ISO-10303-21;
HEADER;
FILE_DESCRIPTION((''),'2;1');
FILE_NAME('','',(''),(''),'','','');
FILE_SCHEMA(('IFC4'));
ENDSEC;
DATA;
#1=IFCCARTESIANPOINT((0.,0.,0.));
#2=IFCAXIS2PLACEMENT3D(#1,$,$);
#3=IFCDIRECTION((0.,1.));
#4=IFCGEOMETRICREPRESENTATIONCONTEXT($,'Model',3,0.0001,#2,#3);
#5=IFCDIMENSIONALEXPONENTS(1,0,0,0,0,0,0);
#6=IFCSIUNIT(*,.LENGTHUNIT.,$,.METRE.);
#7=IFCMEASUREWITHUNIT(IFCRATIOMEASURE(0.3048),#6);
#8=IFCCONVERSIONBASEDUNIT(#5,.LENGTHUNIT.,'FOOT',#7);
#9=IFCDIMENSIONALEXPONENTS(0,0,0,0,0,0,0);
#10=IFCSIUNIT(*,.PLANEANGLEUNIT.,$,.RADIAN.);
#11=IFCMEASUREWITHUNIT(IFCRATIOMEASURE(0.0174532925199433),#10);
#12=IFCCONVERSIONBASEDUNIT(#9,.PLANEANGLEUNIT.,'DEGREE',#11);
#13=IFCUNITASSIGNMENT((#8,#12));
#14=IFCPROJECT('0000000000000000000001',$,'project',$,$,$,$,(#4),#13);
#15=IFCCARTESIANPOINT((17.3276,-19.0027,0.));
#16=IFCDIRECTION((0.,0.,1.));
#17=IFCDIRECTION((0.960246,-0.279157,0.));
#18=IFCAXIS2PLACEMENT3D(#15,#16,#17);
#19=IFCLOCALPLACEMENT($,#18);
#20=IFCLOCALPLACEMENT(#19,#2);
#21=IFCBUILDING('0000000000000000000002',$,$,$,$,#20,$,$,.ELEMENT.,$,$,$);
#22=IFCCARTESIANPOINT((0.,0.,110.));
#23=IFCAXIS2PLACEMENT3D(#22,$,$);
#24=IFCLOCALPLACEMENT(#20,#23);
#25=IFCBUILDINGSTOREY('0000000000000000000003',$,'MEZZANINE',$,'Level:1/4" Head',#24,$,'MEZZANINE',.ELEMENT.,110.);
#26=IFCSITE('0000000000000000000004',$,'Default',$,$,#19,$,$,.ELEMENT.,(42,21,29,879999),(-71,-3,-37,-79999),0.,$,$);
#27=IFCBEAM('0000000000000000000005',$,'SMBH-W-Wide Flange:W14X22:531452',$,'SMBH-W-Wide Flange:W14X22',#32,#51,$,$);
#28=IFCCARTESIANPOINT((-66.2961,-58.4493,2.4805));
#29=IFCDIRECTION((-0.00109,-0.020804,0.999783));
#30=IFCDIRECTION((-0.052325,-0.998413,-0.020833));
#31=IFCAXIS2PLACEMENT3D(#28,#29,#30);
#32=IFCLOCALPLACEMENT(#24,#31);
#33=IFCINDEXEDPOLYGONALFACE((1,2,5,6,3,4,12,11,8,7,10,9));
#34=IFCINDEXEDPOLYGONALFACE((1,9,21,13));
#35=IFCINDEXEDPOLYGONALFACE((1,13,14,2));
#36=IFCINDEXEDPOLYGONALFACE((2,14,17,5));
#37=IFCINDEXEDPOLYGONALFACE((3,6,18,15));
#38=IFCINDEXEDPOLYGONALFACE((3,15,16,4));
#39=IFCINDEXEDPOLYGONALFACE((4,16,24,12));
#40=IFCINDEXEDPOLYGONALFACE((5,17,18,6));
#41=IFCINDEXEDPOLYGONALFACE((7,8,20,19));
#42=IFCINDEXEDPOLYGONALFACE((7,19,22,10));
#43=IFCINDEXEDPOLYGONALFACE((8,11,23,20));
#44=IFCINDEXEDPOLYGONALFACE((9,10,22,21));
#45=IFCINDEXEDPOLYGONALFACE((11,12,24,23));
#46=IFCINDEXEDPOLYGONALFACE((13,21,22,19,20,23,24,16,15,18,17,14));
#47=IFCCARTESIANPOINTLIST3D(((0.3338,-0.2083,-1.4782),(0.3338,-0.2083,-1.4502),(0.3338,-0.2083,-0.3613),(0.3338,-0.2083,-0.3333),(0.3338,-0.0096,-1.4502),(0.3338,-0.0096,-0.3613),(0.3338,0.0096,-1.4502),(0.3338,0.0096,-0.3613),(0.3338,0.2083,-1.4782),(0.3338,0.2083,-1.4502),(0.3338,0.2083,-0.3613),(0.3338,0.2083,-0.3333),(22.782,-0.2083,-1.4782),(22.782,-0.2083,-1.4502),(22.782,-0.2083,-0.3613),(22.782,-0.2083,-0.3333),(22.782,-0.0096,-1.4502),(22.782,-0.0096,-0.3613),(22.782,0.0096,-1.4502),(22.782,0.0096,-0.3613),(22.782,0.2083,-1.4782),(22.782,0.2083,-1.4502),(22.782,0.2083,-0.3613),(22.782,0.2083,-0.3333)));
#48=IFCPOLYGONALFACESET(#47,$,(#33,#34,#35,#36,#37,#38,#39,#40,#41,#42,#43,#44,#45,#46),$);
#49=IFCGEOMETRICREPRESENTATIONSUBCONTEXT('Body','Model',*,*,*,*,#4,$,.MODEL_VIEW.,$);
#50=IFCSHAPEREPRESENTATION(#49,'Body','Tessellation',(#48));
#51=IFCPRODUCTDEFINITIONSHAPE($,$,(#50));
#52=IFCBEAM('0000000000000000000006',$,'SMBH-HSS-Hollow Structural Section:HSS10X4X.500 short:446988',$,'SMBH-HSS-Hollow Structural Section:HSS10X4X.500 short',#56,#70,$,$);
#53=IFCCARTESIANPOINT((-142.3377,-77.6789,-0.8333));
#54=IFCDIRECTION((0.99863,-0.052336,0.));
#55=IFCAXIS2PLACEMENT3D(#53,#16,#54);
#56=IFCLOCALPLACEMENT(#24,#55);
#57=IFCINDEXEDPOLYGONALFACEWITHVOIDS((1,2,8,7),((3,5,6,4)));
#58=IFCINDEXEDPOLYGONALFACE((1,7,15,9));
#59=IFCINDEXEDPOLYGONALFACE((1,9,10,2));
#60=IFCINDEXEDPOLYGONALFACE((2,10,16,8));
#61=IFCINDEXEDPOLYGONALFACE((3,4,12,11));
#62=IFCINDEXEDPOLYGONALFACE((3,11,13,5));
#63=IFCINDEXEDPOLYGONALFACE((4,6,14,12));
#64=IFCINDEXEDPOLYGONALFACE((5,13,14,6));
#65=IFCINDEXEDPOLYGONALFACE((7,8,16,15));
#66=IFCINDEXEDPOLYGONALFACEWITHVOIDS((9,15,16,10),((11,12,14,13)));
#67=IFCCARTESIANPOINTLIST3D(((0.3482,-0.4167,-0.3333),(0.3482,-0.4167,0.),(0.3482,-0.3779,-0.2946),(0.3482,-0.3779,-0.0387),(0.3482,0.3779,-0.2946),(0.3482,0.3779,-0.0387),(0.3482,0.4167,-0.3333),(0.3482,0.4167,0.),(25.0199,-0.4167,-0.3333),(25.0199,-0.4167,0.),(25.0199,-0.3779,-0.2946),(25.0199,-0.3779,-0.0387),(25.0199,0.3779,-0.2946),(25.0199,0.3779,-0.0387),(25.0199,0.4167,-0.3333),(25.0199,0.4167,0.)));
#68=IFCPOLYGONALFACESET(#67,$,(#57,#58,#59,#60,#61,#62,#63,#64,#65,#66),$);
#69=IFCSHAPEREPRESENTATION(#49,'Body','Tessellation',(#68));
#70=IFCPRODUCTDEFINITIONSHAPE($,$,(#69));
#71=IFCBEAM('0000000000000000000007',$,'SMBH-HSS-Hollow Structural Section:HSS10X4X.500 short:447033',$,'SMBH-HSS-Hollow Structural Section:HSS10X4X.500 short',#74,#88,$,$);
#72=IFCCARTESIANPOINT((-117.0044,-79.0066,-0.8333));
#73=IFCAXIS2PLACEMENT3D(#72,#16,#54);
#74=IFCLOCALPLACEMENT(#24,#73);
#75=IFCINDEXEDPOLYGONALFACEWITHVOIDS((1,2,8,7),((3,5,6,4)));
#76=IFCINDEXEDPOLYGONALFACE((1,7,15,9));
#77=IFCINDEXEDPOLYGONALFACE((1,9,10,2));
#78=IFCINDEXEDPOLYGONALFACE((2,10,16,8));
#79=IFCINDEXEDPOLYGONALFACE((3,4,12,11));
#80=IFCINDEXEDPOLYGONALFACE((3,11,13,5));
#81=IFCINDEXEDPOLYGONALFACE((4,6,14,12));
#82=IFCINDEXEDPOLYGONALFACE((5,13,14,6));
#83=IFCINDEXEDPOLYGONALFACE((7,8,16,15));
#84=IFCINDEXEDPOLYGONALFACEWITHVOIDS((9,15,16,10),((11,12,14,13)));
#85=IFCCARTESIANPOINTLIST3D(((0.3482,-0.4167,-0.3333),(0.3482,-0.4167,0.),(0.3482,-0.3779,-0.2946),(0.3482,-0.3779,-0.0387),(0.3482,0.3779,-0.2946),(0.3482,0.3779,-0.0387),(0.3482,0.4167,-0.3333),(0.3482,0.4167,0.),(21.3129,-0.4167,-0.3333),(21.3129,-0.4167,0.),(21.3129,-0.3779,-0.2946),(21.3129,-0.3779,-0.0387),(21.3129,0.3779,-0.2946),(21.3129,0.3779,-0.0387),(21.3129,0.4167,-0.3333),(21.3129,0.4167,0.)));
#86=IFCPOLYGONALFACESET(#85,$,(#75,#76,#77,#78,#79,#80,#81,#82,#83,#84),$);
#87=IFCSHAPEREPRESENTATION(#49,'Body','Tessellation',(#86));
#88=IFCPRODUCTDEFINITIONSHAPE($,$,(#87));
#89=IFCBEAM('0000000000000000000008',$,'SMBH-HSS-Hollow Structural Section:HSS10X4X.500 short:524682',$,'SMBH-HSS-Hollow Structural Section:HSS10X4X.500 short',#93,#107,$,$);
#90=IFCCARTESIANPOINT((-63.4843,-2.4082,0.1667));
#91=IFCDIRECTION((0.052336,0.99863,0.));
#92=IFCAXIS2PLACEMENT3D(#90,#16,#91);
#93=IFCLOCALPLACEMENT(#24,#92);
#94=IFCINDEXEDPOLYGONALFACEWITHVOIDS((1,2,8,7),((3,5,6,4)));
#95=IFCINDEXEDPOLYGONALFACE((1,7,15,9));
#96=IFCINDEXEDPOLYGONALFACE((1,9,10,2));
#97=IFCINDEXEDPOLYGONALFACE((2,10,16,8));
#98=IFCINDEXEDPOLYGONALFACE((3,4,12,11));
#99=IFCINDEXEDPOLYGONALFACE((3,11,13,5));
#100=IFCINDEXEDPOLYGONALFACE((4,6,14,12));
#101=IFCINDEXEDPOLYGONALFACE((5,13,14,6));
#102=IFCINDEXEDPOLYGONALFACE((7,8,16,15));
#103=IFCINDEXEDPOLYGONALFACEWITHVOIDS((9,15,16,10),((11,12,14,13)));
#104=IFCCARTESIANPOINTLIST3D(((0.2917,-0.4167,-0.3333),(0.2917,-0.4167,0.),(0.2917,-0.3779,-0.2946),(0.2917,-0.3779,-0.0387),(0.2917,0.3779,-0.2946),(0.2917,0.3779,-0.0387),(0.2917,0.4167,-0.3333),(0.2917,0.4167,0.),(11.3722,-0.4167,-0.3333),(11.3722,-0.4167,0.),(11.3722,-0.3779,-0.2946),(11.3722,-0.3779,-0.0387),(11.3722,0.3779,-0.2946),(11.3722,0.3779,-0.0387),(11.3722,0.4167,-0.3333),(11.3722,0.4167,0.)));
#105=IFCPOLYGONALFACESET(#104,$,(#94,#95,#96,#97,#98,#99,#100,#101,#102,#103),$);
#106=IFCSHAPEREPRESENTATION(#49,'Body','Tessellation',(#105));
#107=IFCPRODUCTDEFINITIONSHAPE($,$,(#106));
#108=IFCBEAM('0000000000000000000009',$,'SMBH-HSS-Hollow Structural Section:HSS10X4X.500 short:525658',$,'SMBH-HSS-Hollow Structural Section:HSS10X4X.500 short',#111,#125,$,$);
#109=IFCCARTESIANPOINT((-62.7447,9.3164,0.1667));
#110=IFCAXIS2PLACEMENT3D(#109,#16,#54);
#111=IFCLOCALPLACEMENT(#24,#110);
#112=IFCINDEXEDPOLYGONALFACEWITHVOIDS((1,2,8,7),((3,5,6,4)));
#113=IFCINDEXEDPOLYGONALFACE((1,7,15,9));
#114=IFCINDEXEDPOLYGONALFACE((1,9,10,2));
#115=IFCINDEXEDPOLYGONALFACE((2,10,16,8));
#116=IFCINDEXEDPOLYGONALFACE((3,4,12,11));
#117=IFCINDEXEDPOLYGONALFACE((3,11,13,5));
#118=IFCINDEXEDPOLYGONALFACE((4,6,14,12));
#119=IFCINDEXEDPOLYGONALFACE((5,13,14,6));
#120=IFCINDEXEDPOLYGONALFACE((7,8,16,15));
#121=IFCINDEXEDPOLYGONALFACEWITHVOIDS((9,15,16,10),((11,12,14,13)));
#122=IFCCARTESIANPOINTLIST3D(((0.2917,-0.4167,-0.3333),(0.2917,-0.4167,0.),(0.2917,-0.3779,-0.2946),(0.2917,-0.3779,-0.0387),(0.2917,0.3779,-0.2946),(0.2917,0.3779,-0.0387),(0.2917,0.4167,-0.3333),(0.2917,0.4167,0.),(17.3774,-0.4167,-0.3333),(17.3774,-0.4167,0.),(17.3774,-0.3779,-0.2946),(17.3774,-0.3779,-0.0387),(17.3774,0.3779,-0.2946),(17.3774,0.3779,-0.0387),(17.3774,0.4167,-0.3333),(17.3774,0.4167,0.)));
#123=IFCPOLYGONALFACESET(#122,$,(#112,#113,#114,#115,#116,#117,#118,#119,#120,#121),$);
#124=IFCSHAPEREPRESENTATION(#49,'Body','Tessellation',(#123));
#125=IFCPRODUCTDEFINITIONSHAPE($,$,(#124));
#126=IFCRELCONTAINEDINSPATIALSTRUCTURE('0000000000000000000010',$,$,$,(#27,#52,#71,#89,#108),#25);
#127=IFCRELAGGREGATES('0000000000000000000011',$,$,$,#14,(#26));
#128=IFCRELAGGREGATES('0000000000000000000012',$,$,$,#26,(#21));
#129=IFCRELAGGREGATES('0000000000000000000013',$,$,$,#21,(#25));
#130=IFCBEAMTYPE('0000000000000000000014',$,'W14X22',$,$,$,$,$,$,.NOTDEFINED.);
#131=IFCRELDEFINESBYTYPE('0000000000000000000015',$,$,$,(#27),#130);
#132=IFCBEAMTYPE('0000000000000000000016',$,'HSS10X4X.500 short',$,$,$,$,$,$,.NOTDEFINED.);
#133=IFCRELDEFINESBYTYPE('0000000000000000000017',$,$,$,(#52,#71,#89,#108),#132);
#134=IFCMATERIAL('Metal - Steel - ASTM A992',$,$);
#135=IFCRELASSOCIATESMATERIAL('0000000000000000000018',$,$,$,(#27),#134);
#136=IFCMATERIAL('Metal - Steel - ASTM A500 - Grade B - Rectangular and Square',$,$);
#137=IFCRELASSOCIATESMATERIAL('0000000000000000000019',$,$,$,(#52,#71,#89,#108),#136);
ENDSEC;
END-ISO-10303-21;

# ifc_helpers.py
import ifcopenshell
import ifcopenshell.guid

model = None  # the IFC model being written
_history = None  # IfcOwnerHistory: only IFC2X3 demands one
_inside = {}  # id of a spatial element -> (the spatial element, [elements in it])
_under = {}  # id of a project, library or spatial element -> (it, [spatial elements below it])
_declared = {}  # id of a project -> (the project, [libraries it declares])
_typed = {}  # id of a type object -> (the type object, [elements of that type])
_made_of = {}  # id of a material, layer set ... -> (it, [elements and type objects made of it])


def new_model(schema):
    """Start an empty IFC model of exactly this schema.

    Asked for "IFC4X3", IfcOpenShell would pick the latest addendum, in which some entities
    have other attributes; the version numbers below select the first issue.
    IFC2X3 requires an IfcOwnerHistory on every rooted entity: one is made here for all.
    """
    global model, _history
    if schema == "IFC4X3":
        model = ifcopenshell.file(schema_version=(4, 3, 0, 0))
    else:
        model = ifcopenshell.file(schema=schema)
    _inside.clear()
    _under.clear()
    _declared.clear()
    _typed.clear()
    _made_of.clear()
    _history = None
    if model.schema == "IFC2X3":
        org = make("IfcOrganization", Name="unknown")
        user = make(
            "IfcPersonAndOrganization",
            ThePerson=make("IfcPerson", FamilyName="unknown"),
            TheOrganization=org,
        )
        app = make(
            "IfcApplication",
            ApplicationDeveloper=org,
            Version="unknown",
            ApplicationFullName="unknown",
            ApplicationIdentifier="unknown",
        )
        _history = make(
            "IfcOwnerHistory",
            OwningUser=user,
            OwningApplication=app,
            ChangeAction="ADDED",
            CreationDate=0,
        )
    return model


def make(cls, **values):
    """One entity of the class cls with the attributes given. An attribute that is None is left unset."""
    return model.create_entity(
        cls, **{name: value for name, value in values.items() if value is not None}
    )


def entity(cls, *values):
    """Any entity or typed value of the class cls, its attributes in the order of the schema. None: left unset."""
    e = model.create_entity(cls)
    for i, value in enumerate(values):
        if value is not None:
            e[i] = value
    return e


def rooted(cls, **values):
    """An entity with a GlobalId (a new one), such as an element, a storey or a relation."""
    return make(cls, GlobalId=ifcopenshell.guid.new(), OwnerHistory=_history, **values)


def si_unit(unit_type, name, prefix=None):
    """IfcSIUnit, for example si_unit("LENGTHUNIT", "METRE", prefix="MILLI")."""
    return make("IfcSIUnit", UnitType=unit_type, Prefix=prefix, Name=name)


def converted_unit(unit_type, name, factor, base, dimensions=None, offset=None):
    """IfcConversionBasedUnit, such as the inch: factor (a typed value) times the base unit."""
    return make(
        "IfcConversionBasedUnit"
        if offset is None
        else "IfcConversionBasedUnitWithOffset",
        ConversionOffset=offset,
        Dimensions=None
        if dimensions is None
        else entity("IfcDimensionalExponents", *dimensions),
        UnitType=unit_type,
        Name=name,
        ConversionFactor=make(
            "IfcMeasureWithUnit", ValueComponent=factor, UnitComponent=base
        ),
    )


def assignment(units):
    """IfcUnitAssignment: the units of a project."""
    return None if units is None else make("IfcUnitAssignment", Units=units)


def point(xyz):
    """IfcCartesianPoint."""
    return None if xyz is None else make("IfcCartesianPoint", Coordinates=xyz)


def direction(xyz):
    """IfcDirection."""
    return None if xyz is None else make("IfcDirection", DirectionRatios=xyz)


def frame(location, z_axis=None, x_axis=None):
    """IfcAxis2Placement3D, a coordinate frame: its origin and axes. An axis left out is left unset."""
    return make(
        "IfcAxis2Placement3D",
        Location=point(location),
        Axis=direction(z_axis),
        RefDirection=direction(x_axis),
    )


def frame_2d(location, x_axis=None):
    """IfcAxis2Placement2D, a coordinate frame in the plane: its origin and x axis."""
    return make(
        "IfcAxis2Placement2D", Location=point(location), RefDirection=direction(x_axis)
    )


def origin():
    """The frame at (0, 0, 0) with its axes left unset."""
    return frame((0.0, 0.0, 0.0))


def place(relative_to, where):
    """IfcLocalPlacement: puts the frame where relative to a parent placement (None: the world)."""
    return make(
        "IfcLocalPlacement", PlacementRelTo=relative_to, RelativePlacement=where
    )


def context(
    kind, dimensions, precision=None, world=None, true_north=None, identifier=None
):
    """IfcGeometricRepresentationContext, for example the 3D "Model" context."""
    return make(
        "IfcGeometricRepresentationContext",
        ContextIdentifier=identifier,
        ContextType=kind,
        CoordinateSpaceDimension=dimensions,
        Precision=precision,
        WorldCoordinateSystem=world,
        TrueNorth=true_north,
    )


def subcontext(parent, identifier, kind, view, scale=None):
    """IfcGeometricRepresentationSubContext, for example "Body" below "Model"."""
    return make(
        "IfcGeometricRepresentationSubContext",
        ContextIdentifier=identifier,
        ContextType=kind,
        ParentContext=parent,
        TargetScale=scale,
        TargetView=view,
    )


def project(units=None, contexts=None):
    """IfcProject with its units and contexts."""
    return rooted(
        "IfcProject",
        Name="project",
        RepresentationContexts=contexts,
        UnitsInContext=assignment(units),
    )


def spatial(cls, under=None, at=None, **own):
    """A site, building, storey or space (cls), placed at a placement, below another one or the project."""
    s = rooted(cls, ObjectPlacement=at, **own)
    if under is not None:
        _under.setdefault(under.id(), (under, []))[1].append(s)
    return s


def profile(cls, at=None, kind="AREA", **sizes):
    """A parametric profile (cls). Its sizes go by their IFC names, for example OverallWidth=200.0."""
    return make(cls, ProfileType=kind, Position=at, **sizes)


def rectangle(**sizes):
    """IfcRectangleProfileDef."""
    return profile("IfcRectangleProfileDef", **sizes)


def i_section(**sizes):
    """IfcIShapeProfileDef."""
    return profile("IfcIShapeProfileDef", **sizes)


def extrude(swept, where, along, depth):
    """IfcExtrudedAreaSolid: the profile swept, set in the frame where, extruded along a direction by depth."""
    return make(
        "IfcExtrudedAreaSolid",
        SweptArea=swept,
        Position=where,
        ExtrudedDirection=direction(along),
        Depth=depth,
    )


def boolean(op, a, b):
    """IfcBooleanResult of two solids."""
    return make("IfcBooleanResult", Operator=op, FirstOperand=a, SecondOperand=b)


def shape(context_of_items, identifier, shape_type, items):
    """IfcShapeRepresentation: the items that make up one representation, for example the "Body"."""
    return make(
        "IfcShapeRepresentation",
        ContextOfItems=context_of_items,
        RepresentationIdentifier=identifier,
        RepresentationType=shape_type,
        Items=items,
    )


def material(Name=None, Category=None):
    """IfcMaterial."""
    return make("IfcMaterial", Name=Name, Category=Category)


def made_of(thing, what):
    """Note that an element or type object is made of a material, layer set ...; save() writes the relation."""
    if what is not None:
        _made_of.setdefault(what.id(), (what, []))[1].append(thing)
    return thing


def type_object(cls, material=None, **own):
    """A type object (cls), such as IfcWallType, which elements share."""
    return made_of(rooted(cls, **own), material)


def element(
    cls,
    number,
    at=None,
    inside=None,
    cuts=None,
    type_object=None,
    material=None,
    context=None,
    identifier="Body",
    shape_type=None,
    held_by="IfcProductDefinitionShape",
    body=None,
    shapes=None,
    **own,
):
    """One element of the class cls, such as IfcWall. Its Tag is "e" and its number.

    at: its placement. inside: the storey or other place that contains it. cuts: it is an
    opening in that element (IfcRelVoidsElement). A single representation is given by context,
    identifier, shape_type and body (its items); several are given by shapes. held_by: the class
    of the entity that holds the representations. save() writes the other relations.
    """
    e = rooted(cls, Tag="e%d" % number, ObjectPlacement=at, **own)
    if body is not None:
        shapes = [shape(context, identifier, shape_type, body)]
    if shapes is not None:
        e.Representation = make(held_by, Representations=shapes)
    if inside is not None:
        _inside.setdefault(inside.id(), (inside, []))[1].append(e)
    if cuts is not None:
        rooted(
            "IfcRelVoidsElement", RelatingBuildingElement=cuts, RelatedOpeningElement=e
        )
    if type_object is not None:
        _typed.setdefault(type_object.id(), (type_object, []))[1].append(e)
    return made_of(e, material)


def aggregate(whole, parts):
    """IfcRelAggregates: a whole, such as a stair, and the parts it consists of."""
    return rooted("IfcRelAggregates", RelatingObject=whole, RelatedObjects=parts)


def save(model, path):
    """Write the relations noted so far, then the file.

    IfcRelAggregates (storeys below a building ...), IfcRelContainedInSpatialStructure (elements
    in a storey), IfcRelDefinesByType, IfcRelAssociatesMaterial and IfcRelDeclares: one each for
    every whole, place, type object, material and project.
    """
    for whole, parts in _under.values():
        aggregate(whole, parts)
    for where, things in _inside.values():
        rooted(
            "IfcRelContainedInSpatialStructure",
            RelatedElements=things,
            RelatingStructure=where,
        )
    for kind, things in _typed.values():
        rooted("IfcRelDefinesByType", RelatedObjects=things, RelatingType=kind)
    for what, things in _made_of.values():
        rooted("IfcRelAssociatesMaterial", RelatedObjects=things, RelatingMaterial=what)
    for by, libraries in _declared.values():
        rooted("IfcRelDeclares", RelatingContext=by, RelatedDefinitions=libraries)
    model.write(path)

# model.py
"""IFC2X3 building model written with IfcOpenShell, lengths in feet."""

from ifc_helpers import new_model, entity, si_unit, converted_unit, direction, frame, frame_2d, origin, place, context, subcontext, project, spatial, rectangle, i_section, extrude, boolean, material, type_object, element, save


model = new_model("IFC2X3")

# Units and contexts
model_context = context("Model", 3, precision=0.0001, world=origin(), true_north=direction((0.0, 1.0)))
body_context = subcontext(model_context, "Body", "Model", "MODEL_VIEW")
ifc_project = project(units=[converted_unit("LENGTHUNIT", "FOOT", entity("IfcRatioMeasure", 0.3048), si_unit("LENGTHUNIT", "METRE"), dimensions=[1, 0, 0, 0, 0, 0, 0]), converted_unit("PLANEANGLEUNIT", "DEGREE", entity("IfcRatioMeasure", 0.0174532925199433), si_unit("PLANEANGLEUNIT", "RADIAN"), dimensions=[0, 0, 0, 0, 0, 0, 0])], contexts=[model_context])

# Site, building, storey
site_placement = place(None, frame((17.3276, -19.0027, 0.0), z_axis=(0.0, 0.0, 1.0), x_axis=(0.960246, -0.279157, 0.0)))
site = spatial("IfcSite", under=ifc_project, at=site_placement, Name="Default", CompositionType="ELEMENT", RefLatitude=(42, 21, 29, 879999), RefLongitude=(-71, -3, -37, -79999), RefElevation=0.0)
building_placement = place(site_placement, origin())
building = spatial("IfcBuilding", under=site, at=building_placement, CompositionType="ELEMENT")
storey_placement = place(building_placement, frame((0.0, 0.0, 110.0)))
storey = spatial("IfcBuildingStorey", under=building, at=storey_placement, Name="MEZZANINE", ObjectType="Level:1/4\" Head", LongName="MEZZANINE", CompositionType="ELEMENT", Elevation=110.0)

# Beams
ifc_material_1 = material(Name="Metal - Steel - ASTM A992")
beam_type_1 = type_object("IfcBeamType", Name="W14X22", PredefinedType="NOTDEFINED")
beam_1_placement = place(storey_placement, frame((-66.2961, -58.4493, 2.4805), z_axis=(-0.00109, -0.020804, 0.999783), x_axis=(-0.052325, -0.998413, -0.020833)))
element("IfcBeam", 1, at=beam_1_placement, inside=storey, type_object=beam_type_1, material=ifc_material_1, Name="SMBH-W-Wide Flange:W14X22:531452", ObjectType="SMBH-W-Wide Flange:W14X22", context=body_context, shape_type="SweptSolid", body=[
    extrude(i_section(OverallWidth=0.4167, OverallDepth=1.1449, WebThickness=0.0192, FlangeThickness=0.028, at=frame_2d((0.0, 0.0), x_axis=(0.0, 1.0))), frame((0.3338, 0.0, -0.9058), z_axis=(1.0, 0.0, 0.0), x_axis=(0.0, 0.0, -1.0)), (0.0, 0.0, 1.0), 22.4482),
])
ifc_material_2 = material(Name="Metal - Steel - ASTM A500 - Grade B - Rectangular and Square")
beam_type_2 = type_object("IfcBeamType", Name="HSS10X4X.500 short", PredefinedType="NOTDEFINED")
beam_2_placement = place(storey_placement, frame((-142.3377, -77.6789, -0.8333), z_axis=(0.0, 0.0, 1.0), x_axis=(0.99863, -0.052336, 0.0)))
element("IfcBeam", 2, at=beam_2_placement, inside=storey, type_object=beam_type_2, material=ifc_material_2, Name="SMBH-HSS-Hollow Structural Section:HSS10X4X.500 short:446988", ObjectType="SMBH-HSS-Hollow Structural Section:HSS10X4X.500 short", context=body_context, shape_type="SweptSolid", body=[
    boolean("DIFFERENCE", extrude(rectangle(XDim=0.3333, YDim=0.8333, at=frame_2d((0.0, 0.0), x_axis=(1.0, 0.0))), frame((0.3482, 0.0, -0.1667), z_axis=(1.0, 0.0, 0.0), x_axis=(0.0, 0.0, -1.0)), (0.0, 0.0, 1.0), 24.6717), extrude(rectangle(XDim=0.2559, YDim=0.7559, at=frame_2d((0.0, 0.0), x_axis=(0.0, 1.0))), frame((25.0199, 0.0, -0.1667), z_axis=(-1.0, 0.0, 0.0), x_axis=(0.0, 1.0, 0.0)), (0.0, 0.0, 1.0), 24.6717)),
])
beam_3_placement = place(storey_placement, frame((-117.0044, -79.0066, -0.8333), z_axis=(0.0, 0.0, 1.0), x_axis=(0.99863, -0.052336, 0.0)))
element("IfcBeam", 3, at=beam_3_placement, inside=storey, type_object=beam_type_2, material=ifc_material_2, Name="SMBH-HSS-Hollow Structural Section:HSS10X4X.500 short:447033", ObjectType="SMBH-HSS-Hollow Structural Section:HSS10X4X.500 short", context=body_context, shape_type="SweptSolid", body=[
    boolean("DIFFERENCE", extrude(rectangle(XDim=0.3333, YDim=0.8333, at=frame_2d((0.0, 0.0), x_axis=(1.0, 0.0))), frame((0.3482, 0.0, -0.1667), z_axis=(1.0, 0.0, 0.0), x_axis=(0.0, 0.0, -1.0)), (0.0, 0.0, 1.0), 20.9647), extrude(rectangle(XDim=0.2559, YDim=0.7559, at=frame_2d((0.0, 0.0), x_axis=(0.0, 1.0))), frame((21.3129, 0.0, -0.1667), z_axis=(-1.0, 0.0, 0.0), x_axis=(0.0, 1.0, 0.0)), (0.0, 0.0, 1.0), 20.9647)),
])
beam_4_placement = place(storey_placement, frame((-63.4843, -2.4082, 0.1667), z_axis=(0.0, 0.0, 1.0), x_axis=(0.052336, 0.99863, 0.0)))
element("IfcBeam", 4, at=beam_4_placement, inside=storey, type_object=beam_type_2, material=ifc_material_2, Name="SMBH-HSS-Hollow Structural Section:HSS10X4X.500 short:524682", ObjectType="SMBH-HSS-Hollow Structural Section:HSS10X4X.500 short", context=body_context, shape_type="SweptSolid", body=[
    boolean("DIFFERENCE", extrude(rectangle(XDim=0.3333, YDim=0.8333, at=frame_2d((0.0, 0.0), x_axis=(1.0, 0.0))), frame((0.2917, 0.0, -0.1667), z_axis=(1.0, 0.0, 0.0), x_axis=(0.0, 0.0, -1.0)), (0.0, 0.0, 1.0), 11.0805), extrude(rectangle(XDim=0.2559, YDim=0.7559, at=frame_2d((0.0, 0.0), x_axis=(0.0, 1.0))), frame((11.3722, 0.0, -0.1667), z_axis=(-1.0, 0.0, 0.0), x_axis=(0.0, 1.0, 0.0)), (0.0, 0.0, 1.0), 11.0805)),
])
beam_5_placement = place(storey_placement, frame((-62.7447, 9.3164, 0.1667), z_axis=(0.0, 0.0, 1.0), x_axis=(0.99863, -0.052336, 0.0)))
element("IfcBeam", 5, at=beam_5_placement, inside=storey, type_object=beam_type_2, material=ifc_material_2, Name="SMBH-HSS-Hollow Structural Section:HSS10X4X.500 short:525658", ObjectType="SMBH-HSS-Hollow Structural Section:HSS10X4X.500 short", context=body_context, shape_type="SweptSolid", body=[
    boolean("DIFFERENCE", extrude(rectangle(XDim=0.3333, YDim=0.8333, at=frame_2d((0.0, 0.0), x_axis=(1.0, 0.0))), frame((0.2917, 0.0, -0.1667), z_axis=(1.0, 0.0, 0.0), x_axis=(0.0, 0.0, -1.0)), (0.0, 0.0, 1.0), 17.0857), extrude(rectangle(XDim=0.2559, YDim=0.7559, at=frame_2d((0.0, 0.0), x_axis=(0.0, 1.0))), frame((17.3774, 0.0, -0.1667), z_axis=(-1.0, 0.0, 0.0), x_axis=(0.0, 1.0, 0.0)), (0.0, 0.0, 1.0), 17.0857)),
])

save(model, "model.ifc")
